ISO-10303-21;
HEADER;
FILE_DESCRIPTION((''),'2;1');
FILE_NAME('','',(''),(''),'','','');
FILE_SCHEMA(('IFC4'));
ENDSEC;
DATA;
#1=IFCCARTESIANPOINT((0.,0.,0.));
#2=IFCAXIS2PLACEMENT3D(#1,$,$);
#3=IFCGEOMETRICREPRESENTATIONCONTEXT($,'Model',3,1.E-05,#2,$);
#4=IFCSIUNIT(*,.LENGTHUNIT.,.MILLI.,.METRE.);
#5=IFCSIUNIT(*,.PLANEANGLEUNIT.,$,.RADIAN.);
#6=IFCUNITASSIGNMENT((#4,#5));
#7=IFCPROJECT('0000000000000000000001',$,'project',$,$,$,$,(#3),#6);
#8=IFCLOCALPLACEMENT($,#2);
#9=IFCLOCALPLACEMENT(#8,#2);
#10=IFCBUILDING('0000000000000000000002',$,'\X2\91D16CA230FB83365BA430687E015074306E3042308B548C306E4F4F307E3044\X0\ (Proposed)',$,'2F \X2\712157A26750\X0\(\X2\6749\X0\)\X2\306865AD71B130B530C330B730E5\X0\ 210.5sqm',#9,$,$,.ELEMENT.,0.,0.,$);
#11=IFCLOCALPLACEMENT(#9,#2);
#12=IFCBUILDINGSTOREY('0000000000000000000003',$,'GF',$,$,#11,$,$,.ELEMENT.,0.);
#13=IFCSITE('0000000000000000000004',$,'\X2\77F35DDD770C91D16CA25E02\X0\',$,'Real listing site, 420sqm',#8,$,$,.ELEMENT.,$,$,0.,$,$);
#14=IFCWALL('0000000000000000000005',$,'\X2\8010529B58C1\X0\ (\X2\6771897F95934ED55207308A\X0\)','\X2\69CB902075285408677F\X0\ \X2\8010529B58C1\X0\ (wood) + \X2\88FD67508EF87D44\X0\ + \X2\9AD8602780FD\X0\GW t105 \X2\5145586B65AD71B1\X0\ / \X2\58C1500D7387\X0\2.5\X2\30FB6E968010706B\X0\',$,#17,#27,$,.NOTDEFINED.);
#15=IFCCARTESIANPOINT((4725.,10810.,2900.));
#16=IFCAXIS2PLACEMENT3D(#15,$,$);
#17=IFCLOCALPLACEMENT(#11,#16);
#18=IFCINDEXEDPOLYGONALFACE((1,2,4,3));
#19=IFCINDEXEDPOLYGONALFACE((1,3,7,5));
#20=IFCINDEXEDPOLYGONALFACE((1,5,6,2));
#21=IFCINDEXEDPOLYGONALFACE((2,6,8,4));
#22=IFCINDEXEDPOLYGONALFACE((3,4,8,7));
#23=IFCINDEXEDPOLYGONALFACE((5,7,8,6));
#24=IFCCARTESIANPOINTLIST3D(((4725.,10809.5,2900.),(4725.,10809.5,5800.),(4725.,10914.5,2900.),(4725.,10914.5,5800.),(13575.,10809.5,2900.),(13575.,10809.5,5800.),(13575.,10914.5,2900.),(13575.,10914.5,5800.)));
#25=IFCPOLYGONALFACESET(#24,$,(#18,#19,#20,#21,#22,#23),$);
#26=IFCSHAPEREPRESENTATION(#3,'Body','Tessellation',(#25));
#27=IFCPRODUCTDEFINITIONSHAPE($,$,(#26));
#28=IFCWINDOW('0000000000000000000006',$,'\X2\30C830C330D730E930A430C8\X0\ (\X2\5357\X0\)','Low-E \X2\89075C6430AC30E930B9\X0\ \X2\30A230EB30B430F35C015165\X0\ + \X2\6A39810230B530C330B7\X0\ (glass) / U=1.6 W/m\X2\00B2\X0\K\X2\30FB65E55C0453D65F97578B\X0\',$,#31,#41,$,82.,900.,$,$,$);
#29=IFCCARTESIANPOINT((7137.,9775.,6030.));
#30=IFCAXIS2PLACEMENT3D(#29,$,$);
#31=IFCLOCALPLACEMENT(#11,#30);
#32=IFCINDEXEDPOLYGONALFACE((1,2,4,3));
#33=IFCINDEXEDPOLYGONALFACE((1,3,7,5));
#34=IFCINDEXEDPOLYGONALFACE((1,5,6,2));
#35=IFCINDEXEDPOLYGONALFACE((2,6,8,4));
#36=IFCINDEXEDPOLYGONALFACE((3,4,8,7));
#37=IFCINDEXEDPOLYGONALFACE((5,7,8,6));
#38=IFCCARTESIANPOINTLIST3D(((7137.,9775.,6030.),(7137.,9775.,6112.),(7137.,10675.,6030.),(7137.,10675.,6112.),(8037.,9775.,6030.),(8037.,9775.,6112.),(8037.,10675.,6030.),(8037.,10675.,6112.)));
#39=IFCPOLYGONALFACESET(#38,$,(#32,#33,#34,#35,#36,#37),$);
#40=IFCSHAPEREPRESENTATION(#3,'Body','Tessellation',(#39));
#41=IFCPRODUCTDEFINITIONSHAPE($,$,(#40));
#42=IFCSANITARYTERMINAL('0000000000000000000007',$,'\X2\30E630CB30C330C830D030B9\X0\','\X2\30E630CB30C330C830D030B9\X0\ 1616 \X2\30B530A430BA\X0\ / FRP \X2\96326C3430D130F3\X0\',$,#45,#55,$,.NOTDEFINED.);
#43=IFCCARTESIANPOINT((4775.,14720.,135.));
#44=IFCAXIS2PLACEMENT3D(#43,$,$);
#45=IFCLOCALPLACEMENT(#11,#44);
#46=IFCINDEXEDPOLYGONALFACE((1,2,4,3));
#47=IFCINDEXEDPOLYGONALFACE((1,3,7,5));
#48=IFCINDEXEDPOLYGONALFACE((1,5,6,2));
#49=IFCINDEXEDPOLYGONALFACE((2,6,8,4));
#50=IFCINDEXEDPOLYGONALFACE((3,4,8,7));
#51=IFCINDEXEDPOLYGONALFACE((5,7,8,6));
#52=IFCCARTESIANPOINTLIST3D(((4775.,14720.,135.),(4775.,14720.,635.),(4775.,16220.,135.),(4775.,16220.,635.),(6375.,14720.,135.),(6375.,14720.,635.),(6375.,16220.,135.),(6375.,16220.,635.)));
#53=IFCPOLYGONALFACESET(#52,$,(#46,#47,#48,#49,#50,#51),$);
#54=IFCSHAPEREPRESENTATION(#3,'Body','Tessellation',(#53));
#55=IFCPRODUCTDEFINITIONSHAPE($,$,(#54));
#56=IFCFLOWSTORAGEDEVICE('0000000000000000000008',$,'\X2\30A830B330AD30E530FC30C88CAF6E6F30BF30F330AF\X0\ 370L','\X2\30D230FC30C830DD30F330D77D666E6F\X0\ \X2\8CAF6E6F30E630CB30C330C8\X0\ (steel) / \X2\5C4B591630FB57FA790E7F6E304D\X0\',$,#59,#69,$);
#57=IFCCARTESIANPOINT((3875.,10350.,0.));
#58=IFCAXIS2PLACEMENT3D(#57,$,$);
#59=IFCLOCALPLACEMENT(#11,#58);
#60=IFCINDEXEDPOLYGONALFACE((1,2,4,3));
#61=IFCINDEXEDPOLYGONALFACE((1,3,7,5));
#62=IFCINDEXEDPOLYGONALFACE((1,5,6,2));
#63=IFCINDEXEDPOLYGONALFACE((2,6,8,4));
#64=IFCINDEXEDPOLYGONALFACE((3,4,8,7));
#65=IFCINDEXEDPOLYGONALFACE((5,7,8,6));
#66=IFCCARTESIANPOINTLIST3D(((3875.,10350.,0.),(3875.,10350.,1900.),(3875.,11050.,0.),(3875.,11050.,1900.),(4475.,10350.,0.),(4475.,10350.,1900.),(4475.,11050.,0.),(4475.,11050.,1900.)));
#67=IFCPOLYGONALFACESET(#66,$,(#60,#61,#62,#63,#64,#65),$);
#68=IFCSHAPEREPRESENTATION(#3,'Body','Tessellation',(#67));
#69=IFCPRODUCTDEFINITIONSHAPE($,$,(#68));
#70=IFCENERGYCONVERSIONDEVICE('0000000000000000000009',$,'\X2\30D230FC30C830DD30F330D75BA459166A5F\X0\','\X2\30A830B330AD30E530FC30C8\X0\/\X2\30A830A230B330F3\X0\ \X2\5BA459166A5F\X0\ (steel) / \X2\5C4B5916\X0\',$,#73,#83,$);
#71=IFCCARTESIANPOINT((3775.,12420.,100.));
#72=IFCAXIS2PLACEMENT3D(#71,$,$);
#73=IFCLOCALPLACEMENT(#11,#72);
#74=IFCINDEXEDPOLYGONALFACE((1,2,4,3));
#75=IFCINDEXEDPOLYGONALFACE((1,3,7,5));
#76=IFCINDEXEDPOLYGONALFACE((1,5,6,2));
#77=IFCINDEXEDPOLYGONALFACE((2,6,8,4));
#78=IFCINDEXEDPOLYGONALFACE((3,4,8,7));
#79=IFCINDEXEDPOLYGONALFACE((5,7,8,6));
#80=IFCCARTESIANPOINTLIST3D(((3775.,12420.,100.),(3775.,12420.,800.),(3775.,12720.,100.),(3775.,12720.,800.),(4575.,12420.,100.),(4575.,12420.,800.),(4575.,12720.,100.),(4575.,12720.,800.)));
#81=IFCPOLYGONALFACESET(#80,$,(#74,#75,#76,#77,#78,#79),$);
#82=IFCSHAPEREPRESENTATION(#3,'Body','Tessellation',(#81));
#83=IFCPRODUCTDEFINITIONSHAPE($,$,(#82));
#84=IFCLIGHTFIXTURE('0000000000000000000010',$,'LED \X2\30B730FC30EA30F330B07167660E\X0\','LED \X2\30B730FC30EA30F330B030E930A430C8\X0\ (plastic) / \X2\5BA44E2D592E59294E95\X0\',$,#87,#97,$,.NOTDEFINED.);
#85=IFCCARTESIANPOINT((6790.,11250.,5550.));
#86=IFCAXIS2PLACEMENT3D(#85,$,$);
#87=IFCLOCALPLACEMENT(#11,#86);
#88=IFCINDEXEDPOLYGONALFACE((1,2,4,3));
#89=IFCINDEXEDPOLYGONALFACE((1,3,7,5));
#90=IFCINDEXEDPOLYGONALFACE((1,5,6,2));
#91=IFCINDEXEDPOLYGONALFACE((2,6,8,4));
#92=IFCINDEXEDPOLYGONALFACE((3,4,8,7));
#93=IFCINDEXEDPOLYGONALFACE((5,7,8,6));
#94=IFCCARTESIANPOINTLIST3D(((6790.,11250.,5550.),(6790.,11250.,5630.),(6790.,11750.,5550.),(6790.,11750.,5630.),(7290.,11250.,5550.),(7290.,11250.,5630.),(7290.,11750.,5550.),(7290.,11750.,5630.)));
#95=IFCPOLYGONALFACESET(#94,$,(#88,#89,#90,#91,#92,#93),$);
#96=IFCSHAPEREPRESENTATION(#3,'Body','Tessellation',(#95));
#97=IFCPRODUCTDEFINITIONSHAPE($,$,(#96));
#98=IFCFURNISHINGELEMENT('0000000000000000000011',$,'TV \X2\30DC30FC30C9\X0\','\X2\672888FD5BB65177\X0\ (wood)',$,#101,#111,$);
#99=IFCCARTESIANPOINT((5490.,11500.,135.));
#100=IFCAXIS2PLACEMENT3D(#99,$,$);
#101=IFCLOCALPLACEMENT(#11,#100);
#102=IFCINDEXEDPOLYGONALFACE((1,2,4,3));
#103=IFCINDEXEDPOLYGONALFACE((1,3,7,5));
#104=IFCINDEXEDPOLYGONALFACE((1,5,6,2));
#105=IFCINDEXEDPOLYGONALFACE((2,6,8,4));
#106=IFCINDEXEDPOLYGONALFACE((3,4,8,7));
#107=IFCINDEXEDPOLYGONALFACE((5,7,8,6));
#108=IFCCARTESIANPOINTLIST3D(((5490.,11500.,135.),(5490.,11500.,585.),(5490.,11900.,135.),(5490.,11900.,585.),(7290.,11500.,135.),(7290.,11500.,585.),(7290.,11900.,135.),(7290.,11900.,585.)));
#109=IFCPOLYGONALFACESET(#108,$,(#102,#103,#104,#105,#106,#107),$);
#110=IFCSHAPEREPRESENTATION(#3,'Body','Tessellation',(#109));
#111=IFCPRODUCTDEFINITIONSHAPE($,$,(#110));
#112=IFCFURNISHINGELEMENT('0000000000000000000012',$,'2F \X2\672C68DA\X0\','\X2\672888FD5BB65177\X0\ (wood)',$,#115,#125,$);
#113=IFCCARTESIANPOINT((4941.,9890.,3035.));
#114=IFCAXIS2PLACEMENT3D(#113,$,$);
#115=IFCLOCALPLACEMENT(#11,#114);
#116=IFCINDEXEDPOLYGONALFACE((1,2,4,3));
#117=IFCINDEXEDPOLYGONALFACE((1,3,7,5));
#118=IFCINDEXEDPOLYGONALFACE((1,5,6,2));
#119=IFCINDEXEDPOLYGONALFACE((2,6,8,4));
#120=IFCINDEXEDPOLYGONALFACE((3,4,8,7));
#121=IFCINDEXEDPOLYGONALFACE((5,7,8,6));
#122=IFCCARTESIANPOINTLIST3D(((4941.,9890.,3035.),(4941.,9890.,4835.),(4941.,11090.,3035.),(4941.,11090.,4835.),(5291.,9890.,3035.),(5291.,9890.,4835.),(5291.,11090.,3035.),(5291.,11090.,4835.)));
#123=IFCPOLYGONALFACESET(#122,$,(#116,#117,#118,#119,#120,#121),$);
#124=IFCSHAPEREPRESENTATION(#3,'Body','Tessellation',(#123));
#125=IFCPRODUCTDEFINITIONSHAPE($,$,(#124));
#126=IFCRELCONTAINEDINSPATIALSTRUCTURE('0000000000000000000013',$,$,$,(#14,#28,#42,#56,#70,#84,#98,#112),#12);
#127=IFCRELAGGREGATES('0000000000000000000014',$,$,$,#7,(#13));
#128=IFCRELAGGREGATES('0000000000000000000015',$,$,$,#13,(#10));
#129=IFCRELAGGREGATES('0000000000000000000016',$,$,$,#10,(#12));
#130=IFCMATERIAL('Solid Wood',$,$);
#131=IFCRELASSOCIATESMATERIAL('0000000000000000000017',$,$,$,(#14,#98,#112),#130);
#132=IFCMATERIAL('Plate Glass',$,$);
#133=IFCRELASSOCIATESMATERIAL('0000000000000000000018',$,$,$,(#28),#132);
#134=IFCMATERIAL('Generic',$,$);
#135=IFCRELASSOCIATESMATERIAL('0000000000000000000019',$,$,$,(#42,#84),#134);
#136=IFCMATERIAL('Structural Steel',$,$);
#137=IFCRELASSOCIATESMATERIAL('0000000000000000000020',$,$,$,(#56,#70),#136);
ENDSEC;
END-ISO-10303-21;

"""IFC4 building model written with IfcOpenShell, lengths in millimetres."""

from ifc_helpers import new_model, si_unit, frame, frame_2d, origin, place, context, project, spatial, rectangle, extrude, material, element, save


model = new_model("IFC4")

# Units and contexts
model_context = context("Model", 3, precision=1e-05, world=origin())
ifc_project = project(units=[si_unit("LENGTHUNIT", "METRE", prefix="MILLI"), si_unit("PLANEANGLEUNIT", "RADIAN")], contexts=[model_context])

# Site, building, storey
site_placement = place(None, origin())
site = spatial("IfcSite", under=ifc_project, at=site_placement, Name="石川県金沢市", ObjectType="Real listing site, 420sqm", CompositionType="ELEMENT", RefElevation=0.0)
building_placement = place(site_placement, origin())
building = spatial("IfcBuilding", under=site, at=building_placement, Name="金沢・茶室と縁側のある和の住まい (Proposed)", ObjectType="2F 無垢材(杉)と断熱サッシュ 210.5sqm", CompositionType="ELEMENT", ElevationOfRefHeight=0.0, ElevationOfTerrain=0.0)
storey_placement = place(building_placement, origin())
storey = spatial("IfcBuildingStorey", under=building, at=storey_placement, Name="GF", CompositionType="ELEMENT", Elevation=0.0)

# Shared definitions
ifc_material_1 = material(Name="Solid Wood")

# Wall
wall_1_placement = place(storey_placement, frame((4725.0, 10810.0, 2900.0)))
element("IfcWall", 1, at=wall_1_placement, inside=storey, material=ifc_material_1, Name="耐力壁 (東西間仕切り)", Description="構造用合板 耐力壁 (wood) + 製材軸組 + 高性能GW t105 充填断熱 / 壁倍率2.5・準耐火", PredefinedType="NOTDEFINED", context=model_context, shape_type="SweptSolid", body=[
    extrude(rectangle(XDim=8850.0, YDim=105.0, at=frame_2d((4425.0, 52.0))), frame((4725.0, 10810.0, 2900.0)), (0.0, 0.0, 1.0), 2900.0),
])

# Window
ifc_material_2 = material(Name="Plate Glass")
window_placement = place(storey_placement, frame((7137.0, 9775.0, 6030.0)))
element("IfcWindow", 2, at=window_placement, inside=storey, material=ifc_material_2, Name="トップライト (南)", Description="Low-E 複層ガラス アルゴン封入 + 樹脂サッシ (glass) / U=1.6 W/m²K・日射取得型", OverallHeight=82.0, OverallWidth=900.0, context=model_context, shape_type="SweptSolid", body=[
    extrude(rectangle(XDim=900.0, YDim=900.0, at=frame_2d((450.0, 450.0))), frame((7137.0, 9775.0, 6030.0)), (0.0, 0.0, 1.0), 82.0),
])

# Sanitary terminal
ifc_material_3 = material(Name="Generic")
sanitary_terminal_placement = place(storey_placement, frame((4775.0, 14720.0, 135.0)))
element("IfcSanitaryTerminal", 3, at=sanitary_terminal_placement, inside=storey, material=ifc_material_3, Name="ユニットバス", Description="ユニットバス 1616 サイズ / FRP 防水パン", PredefinedType="NOTDEFINED", context=model_context, shape_type="SweptSolid", body=[
    extrude(rectangle(XDim=1600.0, YDim=1500.0, at=frame_2d((800.0, 750.0))), frame((4775.0, 14720.0, 135.0)), (0.0, 0.0, 1.0), 500.0),
])

# Flow storage device
ifc_material_4 = material(Name="Structural Steel")
flow_storage_device_placement = place(storey_placement, frame((3875.0, 10350.0, 0.0)))
element("IfcFlowStorageDevice", 4, at=flow_storage_device_placement, inside=storey, material=ifc_material_4, Name="エコキュート貯湯タンク 370L", Description="ヒートポンプ給湯 貯湯ユニット (steel) / 屋外・基礎置き", context=model_context, shape_type="SweptSolid", body=[
    extrude(rectangle(XDim=600.0, YDim=700.0, at=frame_2d((300.0, 350.0))), frame((3875.0, 10350.0, 0.0)), (0.0, 0.0, 1.0), 1900.0),
])

# Energy conversion device
energy_conversion_device_placement = place(storey_placement, frame((3775.0, 12420.0, 100.0)))
element("IfcEnergyConversionDevice", 5, at=energy_conversion_device_placement, inside=storey, material=ifc_material_4, Name="ヒートポンプ室外機", Description="エコキュート/エアコン 室外機 (steel) / 屋外", context=model_context, shape_type="SweptSolid", body=[
    extrude(rectangle(XDim=800.0, YDim=300.0, at=frame_2d((400.0, 150.0))), frame((3775.0, 12420.0, 100.0)), (0.0, 0.0, 1.0), 700.0),
])

# Light fixture
light_fixture_placement = place(storey_placement, frame((6790.0, 11250.0, 5550.0)))
element("IfcLightFixture", 6, at=light_fixture_placement, inside=storey, material=ifc_material_3, Name="LED シーリング照明", Description="LED シーリングライト (plastic) / 室中央天井", PredefinedType="NOTDEFINED", context=model_context, shape_type="SweptSolid", body=[
    extrude(rectangle(XDim=500.0, YDim=500.0, at=frame_2d((250.0, 250.0))), frame((6790.0, 11250.0, 5550.0)), (0.0, 0.0, 1.0), 80.0),
])

# Furnishing elements
furnishing_1_placement = place(storey_placement, frame((5490.0, 11500.0, 135.0)))
element("IfcFurnishingElement", 7, at=furnishing_1_placement, inside=storey, material=ifc_material_1, Name="TV ボード", Description="木製家具 (wood)", context=model_context, shape_type="SweptSolid", body=[
    extrude(rectangle(XDim=1800.0, YDim=400.0, at=frame_2d((900.0, 200.0))), frame((5490.0, 11500.0, 135.0)), (0.0, 0.0, 1.0), 450.0),
])
furnishing_2_placement = place(storey_placement, frame((4941.0, 9890.0, 3035.0)))
element("IfcFurnishingElement", 8, at=furnishing_2_placement, inside=storey, material=ifc_material_1, Name="2F 本棚", Description="木製家具 (wood)", context=model_context, shape_type="SweptSolid", body=[
    extrude(rectangle(XDim=350.0, YDim=1200.0, at=frame_2d((175.0, 600.0))), frame((4941.0, 9890.0, 3035.0)), (0.0, 0.0, 1.0), 1800.0),
])

save(model, "model.ifc")
